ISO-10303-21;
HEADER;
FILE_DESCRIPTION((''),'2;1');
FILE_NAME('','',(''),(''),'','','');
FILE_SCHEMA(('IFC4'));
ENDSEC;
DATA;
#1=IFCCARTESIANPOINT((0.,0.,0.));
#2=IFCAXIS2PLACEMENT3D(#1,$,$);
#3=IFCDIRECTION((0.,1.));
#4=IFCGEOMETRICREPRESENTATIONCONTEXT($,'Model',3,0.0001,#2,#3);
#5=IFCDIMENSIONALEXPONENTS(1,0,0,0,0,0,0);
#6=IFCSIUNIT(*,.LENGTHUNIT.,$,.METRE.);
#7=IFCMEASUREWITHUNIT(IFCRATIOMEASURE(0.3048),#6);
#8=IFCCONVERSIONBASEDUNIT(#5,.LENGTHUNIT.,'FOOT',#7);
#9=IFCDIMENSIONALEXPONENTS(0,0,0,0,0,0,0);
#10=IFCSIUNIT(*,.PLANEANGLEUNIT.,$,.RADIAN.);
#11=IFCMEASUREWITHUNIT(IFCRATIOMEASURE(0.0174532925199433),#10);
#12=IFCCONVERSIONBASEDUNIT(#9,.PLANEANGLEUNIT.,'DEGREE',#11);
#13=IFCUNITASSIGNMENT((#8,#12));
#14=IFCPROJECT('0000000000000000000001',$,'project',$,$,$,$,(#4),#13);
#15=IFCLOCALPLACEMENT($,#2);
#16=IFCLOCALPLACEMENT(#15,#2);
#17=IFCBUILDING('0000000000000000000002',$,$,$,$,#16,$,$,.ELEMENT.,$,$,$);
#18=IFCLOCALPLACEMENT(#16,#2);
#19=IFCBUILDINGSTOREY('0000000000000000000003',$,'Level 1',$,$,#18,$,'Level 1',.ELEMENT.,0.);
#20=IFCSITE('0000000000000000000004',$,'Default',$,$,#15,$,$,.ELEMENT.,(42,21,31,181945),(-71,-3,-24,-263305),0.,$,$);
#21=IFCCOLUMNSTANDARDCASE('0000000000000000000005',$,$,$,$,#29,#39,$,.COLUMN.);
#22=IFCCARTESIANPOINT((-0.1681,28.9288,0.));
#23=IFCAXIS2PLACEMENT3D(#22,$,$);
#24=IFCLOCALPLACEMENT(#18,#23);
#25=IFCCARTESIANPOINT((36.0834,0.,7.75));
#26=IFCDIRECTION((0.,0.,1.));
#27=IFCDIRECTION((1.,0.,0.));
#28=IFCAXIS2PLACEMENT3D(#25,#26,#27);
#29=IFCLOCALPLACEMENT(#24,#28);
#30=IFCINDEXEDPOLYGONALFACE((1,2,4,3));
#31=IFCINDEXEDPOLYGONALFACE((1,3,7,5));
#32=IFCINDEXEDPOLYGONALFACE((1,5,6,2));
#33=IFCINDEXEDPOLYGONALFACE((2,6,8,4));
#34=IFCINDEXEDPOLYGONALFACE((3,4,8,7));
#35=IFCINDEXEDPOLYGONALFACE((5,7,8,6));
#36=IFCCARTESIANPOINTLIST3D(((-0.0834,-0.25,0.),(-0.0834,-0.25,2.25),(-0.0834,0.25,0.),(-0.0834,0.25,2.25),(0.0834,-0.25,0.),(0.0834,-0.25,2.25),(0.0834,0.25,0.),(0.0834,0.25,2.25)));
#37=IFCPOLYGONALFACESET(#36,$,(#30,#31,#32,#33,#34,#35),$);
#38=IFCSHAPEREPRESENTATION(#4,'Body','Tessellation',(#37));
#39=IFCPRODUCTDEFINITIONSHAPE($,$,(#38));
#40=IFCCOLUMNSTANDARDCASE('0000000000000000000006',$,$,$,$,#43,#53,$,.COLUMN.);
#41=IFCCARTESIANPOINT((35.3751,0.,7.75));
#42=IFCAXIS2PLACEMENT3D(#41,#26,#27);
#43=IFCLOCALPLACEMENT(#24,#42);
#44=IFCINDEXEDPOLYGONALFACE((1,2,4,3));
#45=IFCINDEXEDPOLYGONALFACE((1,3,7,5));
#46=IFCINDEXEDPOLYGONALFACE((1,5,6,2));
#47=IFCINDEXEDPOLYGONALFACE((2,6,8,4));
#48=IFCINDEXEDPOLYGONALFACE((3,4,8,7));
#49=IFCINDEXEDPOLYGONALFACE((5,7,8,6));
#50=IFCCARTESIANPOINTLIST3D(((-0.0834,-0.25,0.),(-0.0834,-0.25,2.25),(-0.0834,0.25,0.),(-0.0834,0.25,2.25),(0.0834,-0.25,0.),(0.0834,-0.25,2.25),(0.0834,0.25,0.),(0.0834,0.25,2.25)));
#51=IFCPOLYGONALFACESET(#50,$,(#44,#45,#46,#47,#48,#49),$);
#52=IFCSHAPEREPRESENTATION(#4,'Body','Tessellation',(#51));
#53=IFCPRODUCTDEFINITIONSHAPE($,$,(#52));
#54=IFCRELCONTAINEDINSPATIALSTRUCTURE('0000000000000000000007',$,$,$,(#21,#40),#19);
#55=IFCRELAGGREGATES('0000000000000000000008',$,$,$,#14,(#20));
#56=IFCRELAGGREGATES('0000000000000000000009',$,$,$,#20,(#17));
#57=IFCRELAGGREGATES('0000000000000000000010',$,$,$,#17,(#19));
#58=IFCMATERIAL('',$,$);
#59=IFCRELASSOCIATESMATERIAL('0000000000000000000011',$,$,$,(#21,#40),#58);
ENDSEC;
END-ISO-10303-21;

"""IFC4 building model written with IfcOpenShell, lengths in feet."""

from ifc_helpers import new_model, entity, si_unit, converted_unit, direction, frame, origin, place, context, project, spatial, rectangle, extrude, material, element, save


model = new_model("IFC4")

# Units and contexts
model_context = context("Model", 3, precision=0.0001, world=origin(), true_north=direction((0.0, 1.0)))
ifc_project = project(units=[converted_unit("LENGTHUNIT", "FOOT", entity("IfcRatioMeasure", 0.3048), si_unit("LENGTHUNIT", "METRE"), dimensions=[1, 0, 0, 0, 0, 0, 0]), converted_unit("PLANEANGLEUNIT", "DEGREE", entity("IfcRatioMeasure", 0.0174532925199433), si_unit("PLANEANGLEUNIT", "RADIAN"), dimensions=[0, 0, 0, 0, 0, 0, 0])], contexts=[model_context])

# Site, building, storey
site_placement = place(None, origin())
site = spatial("IfcSite", under=ifc_project, at=site_placement, Name="Default", CompositionType="ELEMENT", RefLatitude=(42, 21, 31, 181945), RefLongitude=(-71, -3, -24, -263305), RefElevation=0.0)
building_placement = place(site_placement, origin())
building = spatial("IfcBuilding", under=site, at=building_placement, CompositionType="ELEMENT")
storey_placement = place(building_placement, origin())
storey = spatial("IfcBuildingStorey", under=building, at=storey_placement, Name="Level 1", LongName="Level 1", CompositionType="ELEMENT", Elevation=0.0)

# Columns
placement_1 = place(storey_placement, frame((-0.1681, 28.9288, 0.0)))
ifc_material_1 = material(Name="")
for number, where, z_axis, x_axis in (
    (1, (36.0834, 0.0, 7.75), (0.0, 0.0, 1.0), (1.0, 0.0, 0.0)),
    (2, (35.3751, 0.0, 7.75), (0.0, 0.0, 1.0), (1.0, 0.0, 0.0)),
):
    element("IfcColumnStandardCase", number, at=place(placement_1, frame(where, z_axis=z_axis, x_axis=x_axis)), inside=storey, material=ifc_material_1, PredefinedType="COLUMN", context=model_context, shape_type="SweptSolid", body=[
        extrude(rectangle(XDim=0.1667, YDim=0.5), origin(), (0.0, 0.0, 1.0), 2.25),
    ])

save(model, "model.ifc")
